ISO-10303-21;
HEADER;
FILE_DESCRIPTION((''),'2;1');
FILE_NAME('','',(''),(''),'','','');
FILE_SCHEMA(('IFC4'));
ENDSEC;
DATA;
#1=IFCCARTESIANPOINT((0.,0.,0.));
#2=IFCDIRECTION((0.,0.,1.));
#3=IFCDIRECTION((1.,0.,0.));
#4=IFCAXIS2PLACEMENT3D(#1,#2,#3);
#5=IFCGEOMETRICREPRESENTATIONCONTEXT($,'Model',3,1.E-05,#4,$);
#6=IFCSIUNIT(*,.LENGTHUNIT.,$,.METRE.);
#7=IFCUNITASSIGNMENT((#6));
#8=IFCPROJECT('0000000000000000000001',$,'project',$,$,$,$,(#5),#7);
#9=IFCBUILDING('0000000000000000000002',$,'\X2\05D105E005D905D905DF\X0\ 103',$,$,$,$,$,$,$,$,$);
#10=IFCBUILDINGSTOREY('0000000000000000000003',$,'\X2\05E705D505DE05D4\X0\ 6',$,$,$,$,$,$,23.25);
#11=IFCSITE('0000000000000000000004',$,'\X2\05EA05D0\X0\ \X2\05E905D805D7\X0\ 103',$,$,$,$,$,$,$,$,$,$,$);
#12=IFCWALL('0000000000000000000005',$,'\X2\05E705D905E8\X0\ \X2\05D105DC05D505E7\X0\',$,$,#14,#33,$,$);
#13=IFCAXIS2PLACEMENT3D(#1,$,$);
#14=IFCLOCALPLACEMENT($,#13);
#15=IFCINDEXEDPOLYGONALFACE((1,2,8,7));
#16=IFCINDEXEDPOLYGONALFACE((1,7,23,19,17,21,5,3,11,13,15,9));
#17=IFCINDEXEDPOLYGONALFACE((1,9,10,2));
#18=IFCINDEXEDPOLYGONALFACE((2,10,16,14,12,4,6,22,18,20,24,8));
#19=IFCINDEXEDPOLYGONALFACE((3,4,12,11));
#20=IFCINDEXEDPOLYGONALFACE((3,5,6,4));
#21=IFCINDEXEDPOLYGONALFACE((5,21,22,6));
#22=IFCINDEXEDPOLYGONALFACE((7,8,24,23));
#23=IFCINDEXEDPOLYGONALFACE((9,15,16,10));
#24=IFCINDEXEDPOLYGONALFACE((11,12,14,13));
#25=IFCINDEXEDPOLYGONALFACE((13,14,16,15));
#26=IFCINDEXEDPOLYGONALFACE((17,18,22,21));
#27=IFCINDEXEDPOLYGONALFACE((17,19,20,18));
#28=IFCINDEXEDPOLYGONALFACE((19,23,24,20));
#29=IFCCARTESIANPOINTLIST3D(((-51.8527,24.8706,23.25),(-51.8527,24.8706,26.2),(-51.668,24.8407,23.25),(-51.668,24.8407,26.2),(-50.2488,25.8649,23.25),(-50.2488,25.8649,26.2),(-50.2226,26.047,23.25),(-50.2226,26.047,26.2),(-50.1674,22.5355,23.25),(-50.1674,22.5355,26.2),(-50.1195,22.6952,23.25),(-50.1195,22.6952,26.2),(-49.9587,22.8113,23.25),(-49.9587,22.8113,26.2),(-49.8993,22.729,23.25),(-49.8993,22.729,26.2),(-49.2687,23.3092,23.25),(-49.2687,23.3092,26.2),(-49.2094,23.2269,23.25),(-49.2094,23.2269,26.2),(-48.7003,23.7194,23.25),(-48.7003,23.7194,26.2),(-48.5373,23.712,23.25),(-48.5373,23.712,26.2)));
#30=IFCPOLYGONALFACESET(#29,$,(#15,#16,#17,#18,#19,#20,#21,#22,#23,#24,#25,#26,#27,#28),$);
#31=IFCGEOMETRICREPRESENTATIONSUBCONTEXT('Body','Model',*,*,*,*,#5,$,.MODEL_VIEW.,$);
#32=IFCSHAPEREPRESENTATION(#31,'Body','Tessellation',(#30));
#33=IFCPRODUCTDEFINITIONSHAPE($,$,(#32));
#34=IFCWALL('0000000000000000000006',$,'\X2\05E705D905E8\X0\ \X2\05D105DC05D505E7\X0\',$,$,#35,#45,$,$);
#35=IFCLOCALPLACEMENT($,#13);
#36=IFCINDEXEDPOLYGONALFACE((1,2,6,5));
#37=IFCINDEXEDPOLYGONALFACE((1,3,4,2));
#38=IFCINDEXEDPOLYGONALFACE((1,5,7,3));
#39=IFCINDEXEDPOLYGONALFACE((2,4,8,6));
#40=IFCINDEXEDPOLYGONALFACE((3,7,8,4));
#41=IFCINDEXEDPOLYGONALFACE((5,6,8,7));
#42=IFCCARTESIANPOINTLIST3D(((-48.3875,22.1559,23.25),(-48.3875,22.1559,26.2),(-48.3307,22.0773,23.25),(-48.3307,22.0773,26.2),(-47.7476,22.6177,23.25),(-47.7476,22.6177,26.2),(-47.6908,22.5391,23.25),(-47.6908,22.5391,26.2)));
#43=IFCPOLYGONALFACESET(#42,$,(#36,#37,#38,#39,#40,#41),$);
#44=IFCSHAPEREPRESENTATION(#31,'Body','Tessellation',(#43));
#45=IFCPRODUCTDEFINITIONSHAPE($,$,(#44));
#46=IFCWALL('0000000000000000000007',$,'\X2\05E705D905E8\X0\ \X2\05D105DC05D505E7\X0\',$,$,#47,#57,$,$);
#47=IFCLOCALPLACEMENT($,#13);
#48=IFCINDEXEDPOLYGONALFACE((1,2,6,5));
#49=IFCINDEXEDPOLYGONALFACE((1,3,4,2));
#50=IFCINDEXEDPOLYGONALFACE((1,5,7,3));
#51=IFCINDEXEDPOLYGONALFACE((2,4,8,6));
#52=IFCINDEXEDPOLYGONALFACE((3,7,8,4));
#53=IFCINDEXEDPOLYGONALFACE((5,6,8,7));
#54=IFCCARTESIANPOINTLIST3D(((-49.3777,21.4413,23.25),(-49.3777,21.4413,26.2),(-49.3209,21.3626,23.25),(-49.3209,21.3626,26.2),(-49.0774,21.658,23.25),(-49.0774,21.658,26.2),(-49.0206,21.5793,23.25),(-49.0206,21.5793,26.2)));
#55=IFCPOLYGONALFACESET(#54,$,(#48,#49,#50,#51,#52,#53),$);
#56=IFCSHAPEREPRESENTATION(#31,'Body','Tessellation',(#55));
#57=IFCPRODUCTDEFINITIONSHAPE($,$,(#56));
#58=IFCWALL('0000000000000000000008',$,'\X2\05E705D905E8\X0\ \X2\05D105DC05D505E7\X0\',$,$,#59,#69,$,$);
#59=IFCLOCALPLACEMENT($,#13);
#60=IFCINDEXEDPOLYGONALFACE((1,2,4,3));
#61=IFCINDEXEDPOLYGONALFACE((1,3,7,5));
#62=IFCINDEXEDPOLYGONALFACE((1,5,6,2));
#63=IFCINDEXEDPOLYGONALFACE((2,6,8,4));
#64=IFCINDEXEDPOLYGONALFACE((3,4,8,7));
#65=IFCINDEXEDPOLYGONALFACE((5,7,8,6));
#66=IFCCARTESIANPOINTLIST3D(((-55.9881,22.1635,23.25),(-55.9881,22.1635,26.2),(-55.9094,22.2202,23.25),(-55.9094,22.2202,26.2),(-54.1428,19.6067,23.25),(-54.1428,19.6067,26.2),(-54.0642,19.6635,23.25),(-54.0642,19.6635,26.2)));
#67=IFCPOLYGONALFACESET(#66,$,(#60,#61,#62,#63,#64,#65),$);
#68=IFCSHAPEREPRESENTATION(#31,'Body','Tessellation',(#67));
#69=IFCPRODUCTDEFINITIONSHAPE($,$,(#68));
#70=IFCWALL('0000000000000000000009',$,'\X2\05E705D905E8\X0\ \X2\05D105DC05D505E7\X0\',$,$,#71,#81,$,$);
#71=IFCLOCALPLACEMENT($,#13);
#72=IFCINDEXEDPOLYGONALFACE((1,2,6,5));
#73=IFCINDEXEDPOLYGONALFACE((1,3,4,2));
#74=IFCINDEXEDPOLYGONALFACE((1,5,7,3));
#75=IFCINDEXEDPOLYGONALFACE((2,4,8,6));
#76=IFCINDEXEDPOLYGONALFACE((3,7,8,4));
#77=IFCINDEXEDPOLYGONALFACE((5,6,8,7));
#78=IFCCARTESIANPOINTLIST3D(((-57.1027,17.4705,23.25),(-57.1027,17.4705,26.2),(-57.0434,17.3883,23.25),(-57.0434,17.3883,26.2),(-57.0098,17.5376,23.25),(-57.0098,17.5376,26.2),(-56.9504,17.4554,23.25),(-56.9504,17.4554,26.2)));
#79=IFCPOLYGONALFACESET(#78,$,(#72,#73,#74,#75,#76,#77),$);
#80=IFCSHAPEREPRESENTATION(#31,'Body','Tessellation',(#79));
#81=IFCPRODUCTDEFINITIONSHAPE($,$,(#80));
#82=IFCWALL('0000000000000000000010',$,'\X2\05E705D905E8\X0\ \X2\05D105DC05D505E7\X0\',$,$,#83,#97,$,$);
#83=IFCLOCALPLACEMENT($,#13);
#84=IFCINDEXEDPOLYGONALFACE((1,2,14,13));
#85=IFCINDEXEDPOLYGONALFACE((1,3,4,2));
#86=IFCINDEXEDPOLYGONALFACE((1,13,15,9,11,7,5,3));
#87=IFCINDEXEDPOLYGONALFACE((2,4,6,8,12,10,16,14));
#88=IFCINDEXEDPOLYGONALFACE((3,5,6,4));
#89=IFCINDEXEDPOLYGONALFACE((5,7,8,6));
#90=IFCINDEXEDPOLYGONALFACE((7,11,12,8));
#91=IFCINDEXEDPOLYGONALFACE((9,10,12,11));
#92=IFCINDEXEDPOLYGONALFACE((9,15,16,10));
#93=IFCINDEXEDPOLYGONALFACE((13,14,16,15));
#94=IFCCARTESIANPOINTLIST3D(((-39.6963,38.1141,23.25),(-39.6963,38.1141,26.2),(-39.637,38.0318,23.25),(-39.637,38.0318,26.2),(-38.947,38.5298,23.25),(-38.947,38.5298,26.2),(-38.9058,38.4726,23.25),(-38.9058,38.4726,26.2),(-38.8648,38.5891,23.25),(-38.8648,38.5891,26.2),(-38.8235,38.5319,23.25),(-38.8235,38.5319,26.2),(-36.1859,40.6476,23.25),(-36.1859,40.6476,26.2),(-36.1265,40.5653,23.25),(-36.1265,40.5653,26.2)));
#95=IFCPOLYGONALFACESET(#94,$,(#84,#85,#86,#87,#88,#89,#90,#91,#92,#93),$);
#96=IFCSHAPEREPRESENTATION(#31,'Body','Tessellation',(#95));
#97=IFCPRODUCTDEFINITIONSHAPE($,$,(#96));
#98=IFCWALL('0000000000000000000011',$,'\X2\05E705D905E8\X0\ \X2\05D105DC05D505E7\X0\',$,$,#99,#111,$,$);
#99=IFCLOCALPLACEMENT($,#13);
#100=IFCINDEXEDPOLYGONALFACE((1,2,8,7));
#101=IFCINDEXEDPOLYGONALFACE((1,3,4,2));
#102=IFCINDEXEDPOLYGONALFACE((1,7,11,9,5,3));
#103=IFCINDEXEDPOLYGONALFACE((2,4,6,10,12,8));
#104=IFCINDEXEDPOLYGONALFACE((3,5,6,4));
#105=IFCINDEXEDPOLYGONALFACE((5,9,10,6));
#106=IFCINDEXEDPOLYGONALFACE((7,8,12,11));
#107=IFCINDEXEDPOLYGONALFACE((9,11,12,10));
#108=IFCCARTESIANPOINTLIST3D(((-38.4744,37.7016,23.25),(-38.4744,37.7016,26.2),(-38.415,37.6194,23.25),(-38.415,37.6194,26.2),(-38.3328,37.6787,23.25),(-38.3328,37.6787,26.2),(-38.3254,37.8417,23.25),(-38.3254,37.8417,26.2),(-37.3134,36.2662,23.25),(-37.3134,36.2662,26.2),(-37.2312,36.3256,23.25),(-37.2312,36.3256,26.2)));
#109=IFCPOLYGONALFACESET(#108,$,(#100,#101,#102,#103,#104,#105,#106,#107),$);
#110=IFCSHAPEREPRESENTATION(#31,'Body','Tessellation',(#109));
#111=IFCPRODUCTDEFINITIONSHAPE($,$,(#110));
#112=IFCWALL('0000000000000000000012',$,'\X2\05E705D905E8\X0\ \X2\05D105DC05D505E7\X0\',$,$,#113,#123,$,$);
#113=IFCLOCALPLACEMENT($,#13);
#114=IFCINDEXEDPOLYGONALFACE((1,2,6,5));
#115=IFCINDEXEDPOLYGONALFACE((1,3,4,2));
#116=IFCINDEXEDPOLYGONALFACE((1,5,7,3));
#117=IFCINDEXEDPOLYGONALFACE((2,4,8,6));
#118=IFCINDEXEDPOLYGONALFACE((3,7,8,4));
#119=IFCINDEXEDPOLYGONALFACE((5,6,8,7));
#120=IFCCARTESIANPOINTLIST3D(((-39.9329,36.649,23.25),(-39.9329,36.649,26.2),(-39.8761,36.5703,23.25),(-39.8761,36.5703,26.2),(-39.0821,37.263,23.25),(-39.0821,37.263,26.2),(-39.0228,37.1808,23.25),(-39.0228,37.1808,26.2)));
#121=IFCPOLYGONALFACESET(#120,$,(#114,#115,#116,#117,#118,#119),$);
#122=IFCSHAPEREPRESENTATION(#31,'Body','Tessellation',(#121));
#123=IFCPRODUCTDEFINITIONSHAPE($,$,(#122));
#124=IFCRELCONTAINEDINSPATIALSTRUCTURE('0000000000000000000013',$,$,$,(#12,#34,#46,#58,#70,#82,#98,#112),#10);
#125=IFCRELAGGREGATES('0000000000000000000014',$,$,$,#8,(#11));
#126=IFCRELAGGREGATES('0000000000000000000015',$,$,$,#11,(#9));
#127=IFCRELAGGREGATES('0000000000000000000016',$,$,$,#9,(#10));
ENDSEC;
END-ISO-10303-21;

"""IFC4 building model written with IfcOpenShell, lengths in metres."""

from ifc_helpers import new_model, si_unit, frame, origin_with_axes, context, subcontext, project, spatial, polyline, outline, extrude, element, save


model = new_model("IFC4")

# Units and contexts
model_context = context("Model", 3, precision=1e-05, world=origin_with_axes())
body_context = subcontext(model_context, "Body", "Model", "MODEL_VIEW")
ifc_project = project(units=[si_unit("LENGTHUNIT", "METRE")], contexts=[model_context])

# Site, building, storey
site = spatial("IfcSite", under=ifc_project, Name="תא שטח 103")
building = spatial("IfcBuilding", under=site, Name="בניין 103")
storey = spatial("IfcBuildingStorey", under=building, Name="קומה 6", Elevation=23.25)

# Walls
element("IfcWall", 1, inside=storey, Name="קיר בלוק", context=body_context, shape_type="SweptSolid", body=[
    extrude(outline(polyline([(-50.2226, 26.047), (-48.5373, 23.712), (-49.2094, 23.2269), (-49.2687, 23.3092), (-48.7003, 23.7194), (-50.2488, 25.8649), (-51.668, 24.8407), (-50.1195, 22.6952), (-49.9587, 22.8113), (-49.8993, 22.729), (-50.1674, 22.5355), (-51.8527, 24.8706), (-50.2226, 26.047)])), frame((0.0, 0.0, 23.25)), (0.0, 0.0, 1.0), 2.95),
])
element("IfcWall", 2, inside=storey, Name="קיר בלוק", context=body_context, shape_type="SweptSolid", body=[
    extrude(outline(polyline([(-47.6908, 22.5391), (-48.3307, 22.0773), (-48.3875, 22.1559), (-47.7476, 22.6177), (-47.6908, 22.5391)])), frame((0.0, 0.0, 23.25)), (0.0, 0.0, 1.0), 2.95),
])
element("IfcWall", 3, inside=storey, Name="קיר בלוק", context=body_context, shape_type="SweptSolid", body=[
    extrude(outline(polyline([(-49.3209, 21.3626), (-49.3777, 21.4413), (-49.0774, 21.658), (-49.0206, 21.5793), (-49.3209, 21.3626)])), frame((0.0, 0.0, 23.25)), (0.0, 0.0, 1.0), 2.95),
])
element("IfcWall", 4, inside=storey, Name="קיר בלוק", context=body_context, shape_type="SweptSolid", body=[
    extrude(outline(polyline([(-54.0642, 19.6635), (-54.1428, 19.6067), (-55.9881, 22.1635), (-55.9094, 22.2202), (-54.0642, 19.6635)])), frame((0.0, 0.0, 23.25)), (0.0, 0.0, 1.0), 2.95),
])
element("IfcWall", 5, inside=storey, Name="קיר בלוק", context=body_context, shape_type="SweptSolid", body=[
    extrude(outline(polyline([(-57.0434, 17.3883), (-57.1027, 17.4705), (-57.0098, 17.5376), (-56.9504, 17.4554), (-57.0434, 17.3883)])), frame((0.0, 0.0, 23.25)), (0.0, 0.0, 1.0), 2.95),
])
element("IfcWall", 6, inside=storey, Name="קיר בלוק", context=body_context, shape_type="SweptSolid", body=[
    extrude(outline(polyline([(-39.637, 38.0318), (-39.6963, 38.1141), (-36.1859, 40.6476), (-36.1265, 40.5653), (-38.8648, 38.5891), (-38.8235, 38.5319), (-38.9058, 38.4726), (-38.947, 38.5298), (-39.637, 38.0318)])), frame((0.0, 0.0, 23.25)), (0.0, 0.0, 1.0), 2.95),
])
element("IfcWall", 7, inside=storey, Name="קיר בלוק", context=body_context, shape_type="SweptSolid", body=[
    extrude(outline(polyline([(-38.4744, 37.7016), (-38.3254, 37.8417), (-37.2312, 36.3256), (-37.3134, 36.2662), (-38.3328, 37.6787), (-38.415, 37.6194), (-38.4744, 37.7016)])), frame((0.0, 0.0, 23.25)), (0.0, 0.0, 1.0), 2.95),
])
element("IfcWall", 8, inside=storey, Name="קיר בלוק", context=body_context, shape_type="SweptSolid", body=[
    extrude(outline(polyline([(-39.9329, 36.649), (-39.0821, 37.263), (-39.0228, 37.1808), (-39.8761, 36.5703), (-39.9329, 36.649)])), frame((0.0, 0.0, 23.25)), (0.0, 0.0, 1.0), 2.95),
])

save(model, "model.ifc")
